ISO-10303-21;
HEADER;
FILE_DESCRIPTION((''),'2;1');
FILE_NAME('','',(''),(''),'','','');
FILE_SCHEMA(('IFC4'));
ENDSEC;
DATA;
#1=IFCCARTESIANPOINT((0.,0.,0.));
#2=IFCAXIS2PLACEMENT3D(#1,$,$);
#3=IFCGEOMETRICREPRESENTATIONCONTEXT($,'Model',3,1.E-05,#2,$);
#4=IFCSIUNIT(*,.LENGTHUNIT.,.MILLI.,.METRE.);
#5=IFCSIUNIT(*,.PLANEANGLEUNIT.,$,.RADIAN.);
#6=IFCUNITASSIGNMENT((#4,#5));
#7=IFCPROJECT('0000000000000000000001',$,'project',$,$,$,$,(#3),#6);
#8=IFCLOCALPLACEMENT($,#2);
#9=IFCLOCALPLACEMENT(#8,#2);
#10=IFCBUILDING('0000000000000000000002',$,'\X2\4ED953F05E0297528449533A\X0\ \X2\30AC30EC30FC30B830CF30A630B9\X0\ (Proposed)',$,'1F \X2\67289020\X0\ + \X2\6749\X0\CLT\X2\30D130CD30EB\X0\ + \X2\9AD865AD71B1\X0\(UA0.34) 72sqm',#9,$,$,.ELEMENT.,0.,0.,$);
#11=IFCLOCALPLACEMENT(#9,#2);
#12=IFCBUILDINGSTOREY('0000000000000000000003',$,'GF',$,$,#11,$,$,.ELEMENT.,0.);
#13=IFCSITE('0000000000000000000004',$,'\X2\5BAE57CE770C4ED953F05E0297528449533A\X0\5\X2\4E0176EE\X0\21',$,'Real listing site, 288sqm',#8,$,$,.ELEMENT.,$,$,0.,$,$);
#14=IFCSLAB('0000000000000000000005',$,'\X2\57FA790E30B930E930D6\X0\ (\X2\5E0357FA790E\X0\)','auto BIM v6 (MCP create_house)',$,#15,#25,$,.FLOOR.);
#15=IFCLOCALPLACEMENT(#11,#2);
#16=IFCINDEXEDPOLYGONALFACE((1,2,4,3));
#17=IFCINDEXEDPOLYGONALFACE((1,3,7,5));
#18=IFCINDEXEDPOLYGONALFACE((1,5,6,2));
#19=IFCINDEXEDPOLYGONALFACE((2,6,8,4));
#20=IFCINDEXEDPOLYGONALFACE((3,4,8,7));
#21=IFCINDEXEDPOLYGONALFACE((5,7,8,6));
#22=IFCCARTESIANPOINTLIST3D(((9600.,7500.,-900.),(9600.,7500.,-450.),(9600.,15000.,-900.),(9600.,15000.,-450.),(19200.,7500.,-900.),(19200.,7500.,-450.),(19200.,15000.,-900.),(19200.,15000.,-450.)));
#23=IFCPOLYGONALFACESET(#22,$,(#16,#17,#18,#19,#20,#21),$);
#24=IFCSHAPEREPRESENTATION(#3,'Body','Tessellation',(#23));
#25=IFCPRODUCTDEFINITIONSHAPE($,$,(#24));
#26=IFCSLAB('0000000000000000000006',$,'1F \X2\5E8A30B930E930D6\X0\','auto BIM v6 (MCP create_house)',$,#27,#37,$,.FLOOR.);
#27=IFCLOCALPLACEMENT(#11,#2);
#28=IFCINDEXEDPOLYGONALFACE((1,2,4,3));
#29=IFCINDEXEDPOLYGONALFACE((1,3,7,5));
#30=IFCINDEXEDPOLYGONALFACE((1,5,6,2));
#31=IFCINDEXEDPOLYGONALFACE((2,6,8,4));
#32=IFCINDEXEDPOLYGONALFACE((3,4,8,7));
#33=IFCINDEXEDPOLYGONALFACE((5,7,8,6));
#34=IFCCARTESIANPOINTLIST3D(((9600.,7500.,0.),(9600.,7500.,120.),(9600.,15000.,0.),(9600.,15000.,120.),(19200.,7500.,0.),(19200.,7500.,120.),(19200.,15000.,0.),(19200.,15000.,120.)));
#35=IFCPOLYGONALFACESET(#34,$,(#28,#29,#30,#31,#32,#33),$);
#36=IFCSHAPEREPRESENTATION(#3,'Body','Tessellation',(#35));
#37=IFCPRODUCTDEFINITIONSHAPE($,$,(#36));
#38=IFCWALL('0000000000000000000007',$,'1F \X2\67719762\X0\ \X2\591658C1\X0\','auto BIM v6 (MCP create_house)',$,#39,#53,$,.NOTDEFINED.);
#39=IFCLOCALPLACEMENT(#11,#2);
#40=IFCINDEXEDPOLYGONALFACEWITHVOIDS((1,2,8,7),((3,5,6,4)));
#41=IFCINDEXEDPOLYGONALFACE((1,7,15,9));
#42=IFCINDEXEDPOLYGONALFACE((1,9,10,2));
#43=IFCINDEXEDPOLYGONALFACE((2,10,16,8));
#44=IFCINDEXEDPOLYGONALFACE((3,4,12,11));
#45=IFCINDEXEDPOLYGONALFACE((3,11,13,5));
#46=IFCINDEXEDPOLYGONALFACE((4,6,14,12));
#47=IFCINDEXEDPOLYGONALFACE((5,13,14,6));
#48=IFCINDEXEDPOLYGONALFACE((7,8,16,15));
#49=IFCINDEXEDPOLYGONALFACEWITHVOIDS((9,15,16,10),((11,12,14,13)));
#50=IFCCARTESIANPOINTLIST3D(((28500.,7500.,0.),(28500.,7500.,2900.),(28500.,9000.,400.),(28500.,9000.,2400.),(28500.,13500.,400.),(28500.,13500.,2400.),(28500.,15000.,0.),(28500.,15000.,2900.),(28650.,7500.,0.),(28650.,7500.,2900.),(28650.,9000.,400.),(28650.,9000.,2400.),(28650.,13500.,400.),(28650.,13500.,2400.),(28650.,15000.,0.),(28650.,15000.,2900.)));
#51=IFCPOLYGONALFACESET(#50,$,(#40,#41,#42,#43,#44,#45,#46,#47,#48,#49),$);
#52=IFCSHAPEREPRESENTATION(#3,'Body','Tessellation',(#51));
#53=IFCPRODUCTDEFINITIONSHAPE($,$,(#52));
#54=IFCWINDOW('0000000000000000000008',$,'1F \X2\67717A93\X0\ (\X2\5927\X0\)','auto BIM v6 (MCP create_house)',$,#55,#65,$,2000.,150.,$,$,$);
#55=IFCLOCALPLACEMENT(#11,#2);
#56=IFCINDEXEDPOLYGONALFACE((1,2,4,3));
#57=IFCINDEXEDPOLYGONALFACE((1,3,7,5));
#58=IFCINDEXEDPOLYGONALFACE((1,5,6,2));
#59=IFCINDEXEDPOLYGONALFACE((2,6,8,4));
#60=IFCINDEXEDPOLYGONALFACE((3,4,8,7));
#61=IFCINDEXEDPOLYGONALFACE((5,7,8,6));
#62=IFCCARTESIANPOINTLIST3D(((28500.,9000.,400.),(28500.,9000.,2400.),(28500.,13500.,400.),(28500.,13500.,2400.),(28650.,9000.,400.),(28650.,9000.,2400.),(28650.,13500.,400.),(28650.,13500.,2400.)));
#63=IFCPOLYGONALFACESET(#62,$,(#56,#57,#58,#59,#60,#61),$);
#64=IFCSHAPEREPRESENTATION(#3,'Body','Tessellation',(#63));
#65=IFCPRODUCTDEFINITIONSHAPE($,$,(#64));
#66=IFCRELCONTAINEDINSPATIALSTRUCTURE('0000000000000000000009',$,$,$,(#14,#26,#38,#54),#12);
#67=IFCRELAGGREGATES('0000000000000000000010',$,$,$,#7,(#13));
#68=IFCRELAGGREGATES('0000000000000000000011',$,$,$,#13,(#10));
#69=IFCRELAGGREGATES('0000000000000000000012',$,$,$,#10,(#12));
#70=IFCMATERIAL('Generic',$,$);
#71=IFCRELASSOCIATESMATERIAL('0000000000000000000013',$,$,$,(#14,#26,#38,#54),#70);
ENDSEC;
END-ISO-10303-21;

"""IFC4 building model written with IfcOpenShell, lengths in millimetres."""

from ifc_helpers import new_model, si_unit, frame, frame_2d, origin, place, context, project, spatial, rectangle, extrude, material, element, fill, save


model = new_model("IFC4")

# Units and contexts
model_context = context("Model", 3, precision=1e-05, world=origin())
ifc_project = project(units=[si_unit("LENGTHUNIT", "METRE", prefix="MILLI"), si_unit("PLANEANGLEUNIT", "RADIAN")], contexts=[model_context])

# Site, building, storey
site_placement = place(None, origin())
site = spatial("IfcSite", under=ifc_project, at=site_placement, Name="宮城県仙台市青葉区5丁目21", ObjectType="Real listing site, 288sqm", CompositionType="ELEMENT", RefElevation=0.0)
building_placement = place(site_placement, origin())
building = spatial("IfcBuilding", under=site, at=building_placement, Name="仙台市青葉区 ガレージハウス (Proposed)", ObjectType="1F 木造 + 杉CLTパネル + 高断熱(UA0.34) 72sqm", CompositionType="ELEMENT", ElevationOfRefHeight=0.0, ElevationOfTerrain=0.0)
storey_placement = place(building_placement, origin())
storey = spatial("IfcBuildingStorey", under=building, at=storey_placement, Name="GF", CompositionType="ELEMENT", Elevation=0.0)

# Slabs
ifc_material = material(Name="Generic")
slab_1_placement = place(storey_placement, frame((4800.0, 3750.0, -450.0)))
element("IfcSlab", 1, at=slab_1_placement, inside=storey, material=ifc_material, Name="基礎スラブ (布基礎)", Description="auto BIM v6 (MCP create_house)", PredefinedType="FLOOR", context=model_context, shape_type="SweptSolid", body=[
    extrude(rectangle(XDim=9600.0, YDim=7500.0, at=frame_2d((4800.0, 3750.0))), frame((4800.0, 3750.0, -450.0)), (0.0, 0.0, 1.0), 450.0),
])
slab_2_placement = place(storey_placement, frame((4800.0, 3750.0, 0.0)))
element("IfcSlab", 2, at=slab_2_placement, inside=storey, material=ifc_material, Name="1F 床スラブ", Description="auto BIM v6 (MCP create_house)", PredefinedType="FLOOR", context=model_context, shape_type="SweptSolid", body=[
    extrude(rectangle(XDim=9600.0, YDim=7500.0, at=frame_2d((4800.0, 3750.0))), frame((4800.0, 3750.0, 0.0)), (0.0, 0.0, 1.0), 120.0),
])

# Wall, opening, window
wall_1_placement = place(storey_placement, frame((14250.0, 3750.0, 0.0)))
wall_1 = element("IfcWall", 3, at=wall_1_placement, inside=storey, material=ifc_material, Name="1F 東面 外壁", Description="auto BIM v6 (MCP create_house)", PredefinedType="NOTDEFINED", context=model_context, shape_type="SweptSolid", body=[
    extrude(rectangle(XDim=150.0, YDim=7500.0, at=frame_2d((75.0, 3750.0))), frame((14250.0, 3750.0, 0.0)), (0.0, 0.0, 1.0), 2900.0),
])
opening_1_placement = place(storey_placement, frame((14250.0, 4500.0, 200.0)))
opening_1 = element("IfcOpeningElement", 4, at=opening_1_placement, cuts=wall_1, PredefinedType="NOTDEFINED", context=model_context, shape_type="SweptSolid", body=[
    extrude(rectangle(XDim=150.0, YDim=4500.0, at=frame_2d((75.0, 2250.0))), frame((14250.0, 4500.0, 200.0)), (0.0, 0.0, 1.0), 2000.0),
])
window_1_placement = place(storey_placement, frame((14250.0, 4500.0, 200.0)))
window_1 = element("IfcWindow", 5, at=window_1_placement, inside=storey, material=ifc_material, Name="1F 東窓 (大)", Description="auto BIM v6 (MCP create_house)", OverallHeight=2000.0, OverallWidth=150.0, context=model_context, shape_type="SweptSolid", body=[
    extrude(rectangle(XDim=150.0, YDim=4500.0, at=frame_2d((75.0, 2250.0))), frame((14250.0, 4500.0, 200.0)), (0.0, 0.0, 1.0), 2000.0),
])
fill(opening_1, window_1)

save(model, "model.ifc")
